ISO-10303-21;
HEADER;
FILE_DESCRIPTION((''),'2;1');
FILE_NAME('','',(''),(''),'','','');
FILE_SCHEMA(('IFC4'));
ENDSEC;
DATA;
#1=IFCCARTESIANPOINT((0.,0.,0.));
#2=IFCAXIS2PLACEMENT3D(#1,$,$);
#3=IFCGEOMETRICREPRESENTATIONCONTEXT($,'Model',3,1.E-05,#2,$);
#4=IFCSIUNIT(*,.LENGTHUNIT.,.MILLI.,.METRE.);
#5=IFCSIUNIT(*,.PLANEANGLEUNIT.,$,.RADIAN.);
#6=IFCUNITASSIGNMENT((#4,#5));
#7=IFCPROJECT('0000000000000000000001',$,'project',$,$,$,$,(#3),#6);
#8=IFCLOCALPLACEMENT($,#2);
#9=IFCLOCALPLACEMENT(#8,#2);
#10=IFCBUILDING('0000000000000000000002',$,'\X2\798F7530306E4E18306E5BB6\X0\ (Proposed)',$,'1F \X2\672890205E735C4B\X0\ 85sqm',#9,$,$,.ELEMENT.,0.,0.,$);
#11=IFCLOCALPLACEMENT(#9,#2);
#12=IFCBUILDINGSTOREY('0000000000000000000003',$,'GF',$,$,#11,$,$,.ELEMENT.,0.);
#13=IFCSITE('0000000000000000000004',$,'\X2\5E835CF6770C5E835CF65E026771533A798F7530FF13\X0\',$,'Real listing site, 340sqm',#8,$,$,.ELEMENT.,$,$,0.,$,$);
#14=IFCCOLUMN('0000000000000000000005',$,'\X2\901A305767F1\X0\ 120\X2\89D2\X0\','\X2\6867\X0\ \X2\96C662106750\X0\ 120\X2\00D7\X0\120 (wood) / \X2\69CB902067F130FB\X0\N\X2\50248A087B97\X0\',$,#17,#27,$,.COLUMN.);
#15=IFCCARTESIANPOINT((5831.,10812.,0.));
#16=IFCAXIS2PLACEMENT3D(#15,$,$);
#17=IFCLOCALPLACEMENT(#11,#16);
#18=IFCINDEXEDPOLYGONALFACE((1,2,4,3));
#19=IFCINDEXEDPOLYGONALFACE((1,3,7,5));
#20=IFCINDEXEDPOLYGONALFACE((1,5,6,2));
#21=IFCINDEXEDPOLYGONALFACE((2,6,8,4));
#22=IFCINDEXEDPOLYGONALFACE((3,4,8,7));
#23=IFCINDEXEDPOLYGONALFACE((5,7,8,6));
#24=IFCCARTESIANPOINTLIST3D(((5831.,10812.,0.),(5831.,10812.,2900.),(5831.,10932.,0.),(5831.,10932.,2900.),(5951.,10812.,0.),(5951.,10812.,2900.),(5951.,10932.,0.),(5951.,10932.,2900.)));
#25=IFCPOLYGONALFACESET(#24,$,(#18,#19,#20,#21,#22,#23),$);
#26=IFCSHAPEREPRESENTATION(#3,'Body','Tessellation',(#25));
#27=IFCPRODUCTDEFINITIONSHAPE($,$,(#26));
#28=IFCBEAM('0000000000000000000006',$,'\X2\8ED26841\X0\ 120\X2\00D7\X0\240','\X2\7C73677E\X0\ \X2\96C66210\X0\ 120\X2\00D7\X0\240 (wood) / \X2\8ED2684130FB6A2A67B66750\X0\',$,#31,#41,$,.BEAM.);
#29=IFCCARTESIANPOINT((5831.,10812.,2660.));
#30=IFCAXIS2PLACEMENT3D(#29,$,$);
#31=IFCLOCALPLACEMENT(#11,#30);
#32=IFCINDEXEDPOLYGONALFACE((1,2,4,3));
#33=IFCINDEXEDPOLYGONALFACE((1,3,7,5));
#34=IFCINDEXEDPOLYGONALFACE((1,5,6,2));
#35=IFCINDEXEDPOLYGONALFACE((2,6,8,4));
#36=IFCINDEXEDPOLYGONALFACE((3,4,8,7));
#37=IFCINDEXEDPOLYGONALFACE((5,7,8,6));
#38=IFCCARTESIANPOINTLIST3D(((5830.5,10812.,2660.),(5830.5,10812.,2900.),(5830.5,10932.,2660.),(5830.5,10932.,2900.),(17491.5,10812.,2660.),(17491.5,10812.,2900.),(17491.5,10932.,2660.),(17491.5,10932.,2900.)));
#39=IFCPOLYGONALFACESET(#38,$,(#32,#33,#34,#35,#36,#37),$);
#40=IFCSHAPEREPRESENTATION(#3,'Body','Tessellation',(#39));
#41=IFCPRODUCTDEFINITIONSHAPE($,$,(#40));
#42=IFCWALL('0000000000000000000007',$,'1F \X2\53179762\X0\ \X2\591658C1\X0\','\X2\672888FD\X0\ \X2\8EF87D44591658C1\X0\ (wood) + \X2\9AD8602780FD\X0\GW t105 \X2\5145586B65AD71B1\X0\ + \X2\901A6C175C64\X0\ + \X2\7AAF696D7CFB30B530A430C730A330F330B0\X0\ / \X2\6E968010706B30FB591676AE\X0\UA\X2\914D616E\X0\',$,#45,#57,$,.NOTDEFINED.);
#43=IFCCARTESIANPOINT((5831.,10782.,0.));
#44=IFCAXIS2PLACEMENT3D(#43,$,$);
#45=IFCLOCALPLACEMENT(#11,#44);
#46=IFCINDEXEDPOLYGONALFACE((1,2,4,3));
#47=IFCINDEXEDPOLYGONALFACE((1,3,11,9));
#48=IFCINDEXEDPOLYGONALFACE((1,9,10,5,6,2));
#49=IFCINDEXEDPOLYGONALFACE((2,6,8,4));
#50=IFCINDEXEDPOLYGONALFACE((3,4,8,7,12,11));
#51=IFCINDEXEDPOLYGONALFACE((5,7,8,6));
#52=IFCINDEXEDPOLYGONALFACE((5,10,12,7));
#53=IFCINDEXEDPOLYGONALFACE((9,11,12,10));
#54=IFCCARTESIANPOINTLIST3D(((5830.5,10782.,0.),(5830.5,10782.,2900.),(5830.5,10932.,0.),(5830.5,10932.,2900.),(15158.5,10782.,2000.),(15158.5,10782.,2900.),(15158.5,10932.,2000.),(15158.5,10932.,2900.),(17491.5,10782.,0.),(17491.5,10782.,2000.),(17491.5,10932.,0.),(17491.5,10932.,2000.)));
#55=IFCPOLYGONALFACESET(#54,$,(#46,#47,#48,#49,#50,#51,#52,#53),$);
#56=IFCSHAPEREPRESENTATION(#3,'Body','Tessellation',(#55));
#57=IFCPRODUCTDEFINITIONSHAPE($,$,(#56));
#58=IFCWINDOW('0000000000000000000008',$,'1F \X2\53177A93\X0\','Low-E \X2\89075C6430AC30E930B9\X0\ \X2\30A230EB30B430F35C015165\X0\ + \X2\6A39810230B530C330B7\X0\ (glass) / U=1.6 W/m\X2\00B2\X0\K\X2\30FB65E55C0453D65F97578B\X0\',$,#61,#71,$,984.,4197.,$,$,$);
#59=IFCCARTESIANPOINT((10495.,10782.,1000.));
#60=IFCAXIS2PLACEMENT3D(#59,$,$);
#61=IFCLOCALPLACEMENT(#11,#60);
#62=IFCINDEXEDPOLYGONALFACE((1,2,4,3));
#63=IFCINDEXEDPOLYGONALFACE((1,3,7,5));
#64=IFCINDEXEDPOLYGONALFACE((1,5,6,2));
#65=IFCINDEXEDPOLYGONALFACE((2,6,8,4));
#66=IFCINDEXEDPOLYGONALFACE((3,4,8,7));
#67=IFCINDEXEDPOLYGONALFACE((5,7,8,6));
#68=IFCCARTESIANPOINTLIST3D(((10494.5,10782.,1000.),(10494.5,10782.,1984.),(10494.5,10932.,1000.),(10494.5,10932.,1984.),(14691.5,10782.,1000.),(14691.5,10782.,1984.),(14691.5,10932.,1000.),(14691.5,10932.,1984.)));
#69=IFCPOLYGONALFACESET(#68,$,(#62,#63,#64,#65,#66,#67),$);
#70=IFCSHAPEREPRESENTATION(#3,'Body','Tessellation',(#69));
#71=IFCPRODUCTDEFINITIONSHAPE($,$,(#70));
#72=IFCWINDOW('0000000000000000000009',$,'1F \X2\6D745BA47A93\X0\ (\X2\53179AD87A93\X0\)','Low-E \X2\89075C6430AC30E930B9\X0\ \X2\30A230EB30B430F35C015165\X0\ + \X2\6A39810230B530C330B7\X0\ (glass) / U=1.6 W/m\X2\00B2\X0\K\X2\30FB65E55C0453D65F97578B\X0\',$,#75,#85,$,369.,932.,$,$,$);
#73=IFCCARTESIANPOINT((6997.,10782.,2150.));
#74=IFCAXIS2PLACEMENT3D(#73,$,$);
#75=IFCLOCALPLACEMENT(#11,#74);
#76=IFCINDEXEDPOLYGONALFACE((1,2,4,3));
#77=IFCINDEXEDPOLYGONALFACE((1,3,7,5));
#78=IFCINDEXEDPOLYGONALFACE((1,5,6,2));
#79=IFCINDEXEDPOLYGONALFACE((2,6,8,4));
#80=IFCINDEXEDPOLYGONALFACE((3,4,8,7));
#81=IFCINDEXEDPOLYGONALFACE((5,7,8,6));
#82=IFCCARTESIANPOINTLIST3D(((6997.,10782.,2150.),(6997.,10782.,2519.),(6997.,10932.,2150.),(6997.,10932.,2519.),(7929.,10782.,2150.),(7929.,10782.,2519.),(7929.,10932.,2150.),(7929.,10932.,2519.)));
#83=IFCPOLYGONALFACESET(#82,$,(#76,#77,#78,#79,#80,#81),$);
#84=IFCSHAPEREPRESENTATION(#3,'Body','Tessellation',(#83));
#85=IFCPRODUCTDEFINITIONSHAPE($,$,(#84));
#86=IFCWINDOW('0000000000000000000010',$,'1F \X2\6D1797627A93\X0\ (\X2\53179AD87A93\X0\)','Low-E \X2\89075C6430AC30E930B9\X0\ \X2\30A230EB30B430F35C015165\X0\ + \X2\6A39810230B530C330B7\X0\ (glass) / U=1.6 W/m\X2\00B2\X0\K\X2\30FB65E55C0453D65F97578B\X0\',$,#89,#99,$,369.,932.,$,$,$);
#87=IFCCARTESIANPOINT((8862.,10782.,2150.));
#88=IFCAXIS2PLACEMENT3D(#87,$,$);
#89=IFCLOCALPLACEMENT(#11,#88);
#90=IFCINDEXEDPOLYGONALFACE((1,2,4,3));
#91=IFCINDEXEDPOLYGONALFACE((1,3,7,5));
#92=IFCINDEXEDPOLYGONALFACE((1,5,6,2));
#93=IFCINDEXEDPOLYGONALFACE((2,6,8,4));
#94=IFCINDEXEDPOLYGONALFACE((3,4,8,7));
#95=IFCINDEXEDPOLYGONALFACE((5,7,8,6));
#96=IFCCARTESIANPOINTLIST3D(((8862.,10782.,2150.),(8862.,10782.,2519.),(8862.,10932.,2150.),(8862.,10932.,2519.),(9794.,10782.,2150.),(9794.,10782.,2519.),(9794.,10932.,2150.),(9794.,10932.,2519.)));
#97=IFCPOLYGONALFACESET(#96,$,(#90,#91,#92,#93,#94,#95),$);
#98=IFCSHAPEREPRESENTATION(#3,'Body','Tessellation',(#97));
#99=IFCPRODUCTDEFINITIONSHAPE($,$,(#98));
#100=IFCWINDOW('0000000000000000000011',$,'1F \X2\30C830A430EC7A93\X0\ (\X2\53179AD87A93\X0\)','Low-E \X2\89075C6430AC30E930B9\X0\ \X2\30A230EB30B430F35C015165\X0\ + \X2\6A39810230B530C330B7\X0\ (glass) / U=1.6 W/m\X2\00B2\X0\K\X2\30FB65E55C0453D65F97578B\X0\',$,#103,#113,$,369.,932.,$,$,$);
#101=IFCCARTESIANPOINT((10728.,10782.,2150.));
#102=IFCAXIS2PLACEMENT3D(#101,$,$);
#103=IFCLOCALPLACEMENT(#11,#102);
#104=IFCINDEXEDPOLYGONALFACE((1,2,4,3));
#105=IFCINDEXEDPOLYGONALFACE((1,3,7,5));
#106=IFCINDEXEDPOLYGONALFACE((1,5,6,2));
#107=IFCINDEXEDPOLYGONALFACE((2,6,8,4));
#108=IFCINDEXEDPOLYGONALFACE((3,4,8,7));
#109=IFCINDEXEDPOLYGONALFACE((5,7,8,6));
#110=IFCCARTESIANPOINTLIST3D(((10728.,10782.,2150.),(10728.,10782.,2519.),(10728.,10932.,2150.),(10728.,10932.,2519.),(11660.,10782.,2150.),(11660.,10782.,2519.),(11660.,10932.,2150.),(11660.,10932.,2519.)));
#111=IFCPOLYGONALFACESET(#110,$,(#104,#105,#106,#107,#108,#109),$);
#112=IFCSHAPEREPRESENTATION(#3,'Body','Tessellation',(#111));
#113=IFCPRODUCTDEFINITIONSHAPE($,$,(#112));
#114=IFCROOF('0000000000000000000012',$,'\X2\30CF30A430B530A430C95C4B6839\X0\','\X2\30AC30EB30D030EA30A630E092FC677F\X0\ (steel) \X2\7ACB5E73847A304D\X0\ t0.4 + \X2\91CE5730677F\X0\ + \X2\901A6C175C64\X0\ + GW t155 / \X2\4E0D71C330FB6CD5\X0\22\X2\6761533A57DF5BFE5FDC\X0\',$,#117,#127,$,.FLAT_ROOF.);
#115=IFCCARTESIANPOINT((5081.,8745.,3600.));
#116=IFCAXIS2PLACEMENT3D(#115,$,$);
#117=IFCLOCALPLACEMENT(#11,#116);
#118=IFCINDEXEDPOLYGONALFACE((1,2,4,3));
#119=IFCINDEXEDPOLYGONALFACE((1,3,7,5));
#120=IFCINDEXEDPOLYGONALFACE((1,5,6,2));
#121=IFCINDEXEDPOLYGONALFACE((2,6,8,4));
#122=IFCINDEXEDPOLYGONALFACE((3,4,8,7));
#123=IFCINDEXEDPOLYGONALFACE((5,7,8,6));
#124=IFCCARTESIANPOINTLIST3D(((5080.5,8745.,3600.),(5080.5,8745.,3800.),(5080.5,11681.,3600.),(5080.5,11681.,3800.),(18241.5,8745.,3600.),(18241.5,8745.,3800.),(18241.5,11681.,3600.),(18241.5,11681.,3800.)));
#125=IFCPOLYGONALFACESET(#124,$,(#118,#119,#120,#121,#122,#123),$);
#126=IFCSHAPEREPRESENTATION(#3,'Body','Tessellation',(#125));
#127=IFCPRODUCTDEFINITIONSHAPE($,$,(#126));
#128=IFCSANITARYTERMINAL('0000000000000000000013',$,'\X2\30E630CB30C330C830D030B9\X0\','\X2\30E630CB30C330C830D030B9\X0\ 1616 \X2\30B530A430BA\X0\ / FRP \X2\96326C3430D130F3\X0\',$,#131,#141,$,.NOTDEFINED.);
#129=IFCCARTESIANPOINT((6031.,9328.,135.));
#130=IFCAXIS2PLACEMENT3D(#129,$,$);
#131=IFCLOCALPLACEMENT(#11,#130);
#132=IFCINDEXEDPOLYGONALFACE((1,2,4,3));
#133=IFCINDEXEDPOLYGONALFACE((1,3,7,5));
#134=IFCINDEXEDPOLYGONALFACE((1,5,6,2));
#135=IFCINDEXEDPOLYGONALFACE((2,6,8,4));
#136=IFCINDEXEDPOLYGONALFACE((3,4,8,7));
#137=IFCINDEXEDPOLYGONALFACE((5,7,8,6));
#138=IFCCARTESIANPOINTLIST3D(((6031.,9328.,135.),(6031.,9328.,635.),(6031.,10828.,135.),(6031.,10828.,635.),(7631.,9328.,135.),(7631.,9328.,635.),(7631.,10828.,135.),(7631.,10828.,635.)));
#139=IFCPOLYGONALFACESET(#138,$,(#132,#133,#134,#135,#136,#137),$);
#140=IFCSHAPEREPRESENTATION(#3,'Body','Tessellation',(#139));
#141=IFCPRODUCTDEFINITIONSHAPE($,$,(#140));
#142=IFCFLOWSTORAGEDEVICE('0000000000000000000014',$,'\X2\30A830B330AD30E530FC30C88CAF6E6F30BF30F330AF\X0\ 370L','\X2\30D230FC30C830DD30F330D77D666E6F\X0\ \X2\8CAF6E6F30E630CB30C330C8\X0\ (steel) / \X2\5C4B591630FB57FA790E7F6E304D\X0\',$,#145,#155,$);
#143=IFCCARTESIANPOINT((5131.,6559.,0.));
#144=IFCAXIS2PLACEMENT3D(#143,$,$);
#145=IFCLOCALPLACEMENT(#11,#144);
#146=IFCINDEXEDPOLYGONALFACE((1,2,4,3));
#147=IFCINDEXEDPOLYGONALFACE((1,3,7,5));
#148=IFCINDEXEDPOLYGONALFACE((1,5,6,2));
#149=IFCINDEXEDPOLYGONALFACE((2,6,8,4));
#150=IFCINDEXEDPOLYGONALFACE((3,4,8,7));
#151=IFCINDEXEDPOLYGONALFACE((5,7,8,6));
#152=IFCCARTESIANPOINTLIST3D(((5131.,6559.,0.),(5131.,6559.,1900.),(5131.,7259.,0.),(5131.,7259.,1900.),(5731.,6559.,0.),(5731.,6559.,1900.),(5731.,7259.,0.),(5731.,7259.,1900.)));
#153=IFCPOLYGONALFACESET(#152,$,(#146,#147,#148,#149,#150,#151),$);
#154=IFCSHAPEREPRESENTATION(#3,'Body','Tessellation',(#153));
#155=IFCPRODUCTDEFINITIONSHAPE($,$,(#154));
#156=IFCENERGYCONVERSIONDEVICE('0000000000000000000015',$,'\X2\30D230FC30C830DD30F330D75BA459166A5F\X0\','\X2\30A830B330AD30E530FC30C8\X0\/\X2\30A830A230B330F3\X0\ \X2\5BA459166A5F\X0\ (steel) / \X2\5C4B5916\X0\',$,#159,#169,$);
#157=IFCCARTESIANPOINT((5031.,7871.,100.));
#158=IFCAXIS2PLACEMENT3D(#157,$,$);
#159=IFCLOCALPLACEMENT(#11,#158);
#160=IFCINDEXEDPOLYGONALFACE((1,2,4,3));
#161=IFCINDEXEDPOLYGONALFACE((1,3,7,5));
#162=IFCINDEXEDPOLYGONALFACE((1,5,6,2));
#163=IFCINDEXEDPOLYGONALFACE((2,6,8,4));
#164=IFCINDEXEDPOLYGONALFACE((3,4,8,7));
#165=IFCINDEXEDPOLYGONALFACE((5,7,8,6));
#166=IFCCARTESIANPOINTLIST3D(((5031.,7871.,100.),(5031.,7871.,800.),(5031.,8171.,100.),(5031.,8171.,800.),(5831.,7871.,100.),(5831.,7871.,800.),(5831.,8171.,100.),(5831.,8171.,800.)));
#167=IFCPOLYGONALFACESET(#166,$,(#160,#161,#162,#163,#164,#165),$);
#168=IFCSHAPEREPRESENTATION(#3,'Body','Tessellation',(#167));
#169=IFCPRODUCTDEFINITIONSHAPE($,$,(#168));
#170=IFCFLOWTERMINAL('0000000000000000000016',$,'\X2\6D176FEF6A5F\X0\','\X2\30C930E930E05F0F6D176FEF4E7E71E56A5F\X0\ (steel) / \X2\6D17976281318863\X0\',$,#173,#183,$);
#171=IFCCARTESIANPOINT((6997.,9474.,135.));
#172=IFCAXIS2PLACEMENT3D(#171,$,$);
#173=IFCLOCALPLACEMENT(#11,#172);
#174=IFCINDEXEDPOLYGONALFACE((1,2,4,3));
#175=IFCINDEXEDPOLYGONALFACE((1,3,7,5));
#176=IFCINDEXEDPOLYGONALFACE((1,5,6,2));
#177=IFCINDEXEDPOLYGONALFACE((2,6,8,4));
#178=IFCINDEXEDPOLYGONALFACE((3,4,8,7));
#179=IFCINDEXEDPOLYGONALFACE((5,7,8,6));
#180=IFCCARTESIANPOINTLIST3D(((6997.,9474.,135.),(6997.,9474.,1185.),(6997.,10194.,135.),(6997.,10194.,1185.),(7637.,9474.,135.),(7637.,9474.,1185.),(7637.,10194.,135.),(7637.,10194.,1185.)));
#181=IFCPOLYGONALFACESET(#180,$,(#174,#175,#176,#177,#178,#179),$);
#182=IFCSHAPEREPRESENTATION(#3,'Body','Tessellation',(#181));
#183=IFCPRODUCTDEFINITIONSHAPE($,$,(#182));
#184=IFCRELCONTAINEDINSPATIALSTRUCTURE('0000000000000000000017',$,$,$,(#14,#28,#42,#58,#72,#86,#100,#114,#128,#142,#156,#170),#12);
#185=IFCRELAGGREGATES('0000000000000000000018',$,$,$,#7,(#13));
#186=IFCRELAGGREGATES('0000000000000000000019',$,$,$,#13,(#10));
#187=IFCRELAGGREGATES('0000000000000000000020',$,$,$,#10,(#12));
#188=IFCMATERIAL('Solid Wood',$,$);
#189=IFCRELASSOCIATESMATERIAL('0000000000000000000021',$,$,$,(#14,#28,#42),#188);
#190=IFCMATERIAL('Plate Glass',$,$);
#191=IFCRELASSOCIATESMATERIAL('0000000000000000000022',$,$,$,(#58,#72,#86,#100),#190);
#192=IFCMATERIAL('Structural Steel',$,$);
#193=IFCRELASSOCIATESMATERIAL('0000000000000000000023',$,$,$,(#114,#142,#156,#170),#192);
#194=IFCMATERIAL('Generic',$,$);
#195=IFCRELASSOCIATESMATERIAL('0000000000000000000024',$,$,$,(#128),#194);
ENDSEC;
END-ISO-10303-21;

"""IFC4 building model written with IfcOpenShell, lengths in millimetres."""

from ifc_helpers import new_model, si_unit, frame, frame_2d, origin, place, context, project, spatial, rectangle, extrude, material, element, fill, save


model = new_model("IFC4")

# Units and contexts
model_context = context("Model", 3, precision=1e-05, world=origin())
ifc_project = project(units=[si_unit("LENGTHUNIT", "METRE", prefix="MILLI"), si_unit("PLANEANGLEUNIT", "RADIAN")], contexts=[model_context])

# Site, building, storey
site_placement = place(None, origin())
site = spatial("IfcSite", under=ifc_project, at=site_placement, Name="広島県広島市東区福田３", ObjectType="Real listing site, 340sqm", CompositionType="ELEMENT", RefElevation=0.0)
building_placement = place(site_placement, origin())
building = spatial("IfcBuilding", under=site, at=building_placement, Name="福田の丘の家 (Proposed)", ObjectType="1F 木造平屋 85sqm", CompositionType="ELEMENT", ElevationOfRefHeight=0.0, ElevationOfTerrain=0.0)
storey_placement = place(building_placement, origin())
storey = spatial("IfcBuildingStorey", under=building, at=storey_placement, Name="GF", CompositionType="ELEMENT", Elevation=0.0)

# Column
ifc_material_1 = material(Name="Solid Wood")
column_1_placement = place(storey_placement, frame((5831.0, 10812.0, 0.0)))
element("IfcColumn", 1, at=column_1_placement, inside=storey, material=ifc_material_1, Name="通し柱 120角", Description="桧 集成材 120×120 (wood) / 構造柱・N値計算", PredefinedType="COLUMN", context=model_context, shape_type="SweptSolid", body=[
    extrude(rectangle(XDim=120.0, YDim=120.0, at=frame_2d((60.0, 60.0))), frame((5831.0, 10812.0, 0.0)), (0.0, 0.0, 1.0), 2900.0),
])

# Beam
beam_1_placement = place(storey_placement, frame((5831.0, 10812.0, 2660.0)))
element("IfcBeam", 2, at=beam_1_placement, inside=storey, material=ifc_material_1, Name="軒桁 120×240", Description="米松 集成 120×240 (wood) / 軒桁・横架材", PredefinedType="BEAM", context=model_context, shape_type="SweptSolid", body=[
    extrude(rectangle(XDim=11661.0, YDim=120.0, at=frame_2d((5830.0, 60.0))), frame((5831.0, 10812.0, 2660.0)), (0.0, 0.0, 1.0), 240.0),
])

# Wall, openings, windows
wall_1_placement = place(storey_placement, frame((5831.0, 10782.0, 0.0)))
wall_1 = element("IfcWall", 3, at=wall_1_placement, inside=storey, material=ifc_material_1, Name="1F 北面 外壁", Description="木製 軸組外壁 (wood) + 高性能GW t105 充填断熱 + 通気層 + 窯業系サイディング / 準耐火・外皮UA配慮", PredefinedType="NOTDEFINED", context=model_context, shape_type="SweptSolid", body=[
    extrude(rectangle(XDim=11661.0, YDim=150.0, at=frame_2d((5830.0, 75.0))), frame((5831.0, 10782.0, 0.0)), (0.0, 0.0, 1.0), 2900.0),
])
opening_1_placement = place(storey_placement, frame((10495.0, 10782.0, 1000.0)))
opening_1 = element("IfcOpeningElement", 4, at=opening_1_placement, cuts=wall_1, PredefinedType="NOTDEFINED", context=model_context, shape_type="SweptSolid", body=[
    extrude(rectangle(XDim=4197.0, YDim=150.0, at=frame_2d((2098.0, 75.0))), frame((10495.0, 10782.0, 1000.0)), (0.0, 0.0, 1.0), 984.0),
])
opening_2_placement = place(storey_placement, frame((6997.0, 10782.0, 2150.0)))
opening_2 = element("IfcOpeningElement", 5, at=opening_2_placement, cuts=wall_1, PredefinedType="NOTDEFINED", context=model_context, shape_type="SweptSolid", body=[
    extrude(rectangle(XDim=932.0, YDim=150.0, at=frame_2d((466.0, 75.0))), frame((6997.0, 10782.0, 2150.0)), (0.0, 0.0, 1.0), 369.0),
])
opening_3_placement = place(storey_placement, frame((8862.0, 10782.0, 2150.0)))
opening_3 = element("IfcOpeningElement", 6, at=opening_3_placement, cuts=wall_1, PredefinedType="NOTDEFINED", context=model_context, shape_type="SweptSolid", body=[
    extrude(rectangle(XDim=932.0, YDim=150.0, at=frame_2d((466.0, 75.0))), frame((8862.0, 10782.0, 2150.0)), (0.0, 0.0, 1.0), 369.0),
])
opening_4_placement = place(storey_placement, frame((10728.0, 10782.0, 2150.0)))
opening_4 = element("IfcOpeningElement", 7, at=opening_4_placement, cuts=wall_1, PredefinedType="NOTDEFINED", context=model_context, shape_type="SweptSolid", body=[
    extrude(rectangle(XDim=932.0, YDim=150.0, at=frame_2d((466.0, 75.0))), frame((10728.0, 10782.0, 2150.0)), (0.0, 0.0, 1.0), 369.0),
])
ifc_material_2 = material(Name="Plate Glass")
window_1_placement = place(storey_placement, frame((10495.0, 10782.0, 1000.0)))
window_1 = element("IfcWindow", 8, at=window_1_placement, inside=storey, material=ifc_material_2, Name="1F 北窓", Description="Low-E 複層ガラス アルゴン封入 + 樹脂サッシ (glass) / U=1.6 W/m²K・日射取得型", OverallHeight=984.0, OverallWidth=4197.0, context=model_context, shape_type="SweptSolid", body=[
    extrude(rectangle(XDim=4197.0, YDim=150.0, at=frame_2d((2098.0, 75.0))), frame((10495.0, 10782.0, 1000.0)), (0.0, 0.0, 1.0), 984.0),
])
fill(opening_1, window_1)
window_2_placement = place(storey_placement, frame((6997.0, 10782.0, 2150.0)))
window_2 = element("IfcWindow", 9, at=window_2_placement, inside=storey, material=ifc_material_2, Name="1F 浴室窓 (北高窓)", Description="Low-E 複層ガラス アルゴン封入 + 樹脂サッシ (glass) / U=1.6 W/m²K・日射取得型", OverallHeight=369.0, OverallWidth=932.0, context=model_context, shape_type="SweptSolid", body=[
    extrude(rectangle(XDim=932.0, YDim=150.0, at=frame_2d((466.0, 75.0))), frame((6997.0, 10782.0, 2150.0)), (0.0, 0.0, 1.0), 369.0),
])
fill(opening_2, window_2)
window_3_placement = place(storey_placement, frame((8862.0, 10782.0, 2150.0)))
window_3 = element("IfcWindow", 10, at=window_3_placement, inside=storey, material=ifc_material_2, Name="1F 洗面窓 (北高窓)", Description="Low-E 複層ガラス アルゴン封入 + 樹脂サッシ (glass) / U=1.6 W/m²K・日射取得型", OverallHeight=369.0, OverallWidth=932.0, context=model_context, shape_type="SweptSolid", body=[
    extrude(rectangle(XDim=932.0, YDim=150.0, at=frame_2d((466.0, 75.0))), frame((8862.0, 10782.0, 2150.0)), (0.0, 0.0, 1.0), 369.0),
])
fill(opening_3, window_3)
window_4_placement = place(storey_placement, frame((10728.0, 10782.0, 2150.0)))
window_4 = element("IfcWindow", 11, at=window_4_placement, inside=storey, material=ifc_material_2, Name="1F トイレ窓 (北高窓)", Description="Low-E 複層ガラス アルゴン封入 + 樹脂サッシ (glass) / U=1.6 W/m²K・日射取得型", OverallHeight=369.0, OverallWidth=932.0, context=model_context, shape_type="SweptSolid", body=[
    extrude(rectangle(XDim=932.0, YDim=150.0, at=frame_2d((466.0, 75.0))), frame((10728.0, 10782.0, 2150.0)), (0.0, 0.0, 1.0), 369.0),
])
fill(opening_4, window_4)

# Roof
ifc_material_3 = material(Name="Structural Steel")
roof_placement = place(storey_placement, frame((5081.0, 8745.0, 3600.0)))
element("IfcRoof", 12, at=roof_placement, inside=storey, material=ifc_material_3, Name="ハイサイド屋根", Description="ガルバリウム鋼板 (steel) 立平葺き t0.4 + 野地板 + 通気層 + GW t155 / 不燃・法22条区域対応", PredefinedType="FLAT_ROOF", context=model_context, shape_type="SweptSolid", body=[
    extrude(rectangle(XDim=13161.0, YDim=2936.0, at=frame_2d((6580.0, 1468.0))), frame((5081.0, 8745.0, 3600.0)), (0.0, 0.0, 1.0), 200.0),
])

# Sanitary terminal
ifc_material_4 = material(Name="Generic")
sanitary_terminal_placement = place(storey_placement, frame((6031.0, 9328.0, 135.0)))
element("IfcSanitaryTerminal", 13, at=sanitary_terminal_placement, inside=storey, material=ifc_material_4, Name="ユニットバス", Description="ユニットバス 1616 サイズ / FRP 防水パン", PredefinedType="NOTDEFINED", context=model_context, shape_type="SweptSolid", body=[
    extrude(rectangle(XDim=1600.0, YDim=1500.0, at=frame_2d((800.0, 750.0))), frame((6031.0, 9328.0, 135.0)), (0.0, 0.0, 1.0), 500.0),
])

# Flow storage device
flow_storage_device_placement = place(storey_placement, frame((5131.0, 6559.0, 0.0)))
element("IfcFlowStorageDevice", 14, at=flow_storage_device_placement, inside=storey, material=ifc_material_3, Name="エコキュート貯湯タンク 370L", Description="ヒートポンプ給湯 貯湯ユニット (steel) / 屋外・基礎置き", context=model_context, shape_type="SweptSolid", body=[
    extrude(rectangle(XDim=600.0, YDim=700.0, at=frame_2d((300.0, 350.0))), frame((5131.0, 6559.0, 0.0)), (0.0, 0.0, 1.0), 1900.0),
])

# Energy conversion device
energy_conversion_device_placement = place(storey_placement, frame((5031.0, 7871.0, 100.0)))
element("IfcEnergyConversionDevice", 15, at=energy_conversion_device_placement, inside=storey, material=ifc_material_3, Name="ヒートポンプ室外機", Description="エコキュート/エアコン 室外機 (steel) / 屋外", context=model_context, shape_type="SweptSolid", body=[
    extrude(rectangle(XDim=800.0, YDim=300.0, at=frame_2d((400.0, 150.0))), frame((5031.0, 7871.0, 100.0)), (0.0, 0.0, 1.0), 700.0),
])

# Flow terminal
flow_terminal_placement = place(storey_placement, frame((6997.0, 9474.0, 135.0)))
element("IfcFlowTerminal", 16, at=flow_terminal_placement, inside=storey, material=ifc_material_3, Name="洗濯機", Description="ドラム式洗濯乾燥機 (steel) / 洗面脱衣", context=model_context, shape_type="SweptSolid", body=[
    extrude(rectangle(XDim=640.0, YDim=720.0, at=frame_2d((320.0, 360.0))), frame((6997.0, 9474.0, 135.0)), (0.0, 0.0, 1.0), 1050.0),
])

save(model, "model.ifc")
